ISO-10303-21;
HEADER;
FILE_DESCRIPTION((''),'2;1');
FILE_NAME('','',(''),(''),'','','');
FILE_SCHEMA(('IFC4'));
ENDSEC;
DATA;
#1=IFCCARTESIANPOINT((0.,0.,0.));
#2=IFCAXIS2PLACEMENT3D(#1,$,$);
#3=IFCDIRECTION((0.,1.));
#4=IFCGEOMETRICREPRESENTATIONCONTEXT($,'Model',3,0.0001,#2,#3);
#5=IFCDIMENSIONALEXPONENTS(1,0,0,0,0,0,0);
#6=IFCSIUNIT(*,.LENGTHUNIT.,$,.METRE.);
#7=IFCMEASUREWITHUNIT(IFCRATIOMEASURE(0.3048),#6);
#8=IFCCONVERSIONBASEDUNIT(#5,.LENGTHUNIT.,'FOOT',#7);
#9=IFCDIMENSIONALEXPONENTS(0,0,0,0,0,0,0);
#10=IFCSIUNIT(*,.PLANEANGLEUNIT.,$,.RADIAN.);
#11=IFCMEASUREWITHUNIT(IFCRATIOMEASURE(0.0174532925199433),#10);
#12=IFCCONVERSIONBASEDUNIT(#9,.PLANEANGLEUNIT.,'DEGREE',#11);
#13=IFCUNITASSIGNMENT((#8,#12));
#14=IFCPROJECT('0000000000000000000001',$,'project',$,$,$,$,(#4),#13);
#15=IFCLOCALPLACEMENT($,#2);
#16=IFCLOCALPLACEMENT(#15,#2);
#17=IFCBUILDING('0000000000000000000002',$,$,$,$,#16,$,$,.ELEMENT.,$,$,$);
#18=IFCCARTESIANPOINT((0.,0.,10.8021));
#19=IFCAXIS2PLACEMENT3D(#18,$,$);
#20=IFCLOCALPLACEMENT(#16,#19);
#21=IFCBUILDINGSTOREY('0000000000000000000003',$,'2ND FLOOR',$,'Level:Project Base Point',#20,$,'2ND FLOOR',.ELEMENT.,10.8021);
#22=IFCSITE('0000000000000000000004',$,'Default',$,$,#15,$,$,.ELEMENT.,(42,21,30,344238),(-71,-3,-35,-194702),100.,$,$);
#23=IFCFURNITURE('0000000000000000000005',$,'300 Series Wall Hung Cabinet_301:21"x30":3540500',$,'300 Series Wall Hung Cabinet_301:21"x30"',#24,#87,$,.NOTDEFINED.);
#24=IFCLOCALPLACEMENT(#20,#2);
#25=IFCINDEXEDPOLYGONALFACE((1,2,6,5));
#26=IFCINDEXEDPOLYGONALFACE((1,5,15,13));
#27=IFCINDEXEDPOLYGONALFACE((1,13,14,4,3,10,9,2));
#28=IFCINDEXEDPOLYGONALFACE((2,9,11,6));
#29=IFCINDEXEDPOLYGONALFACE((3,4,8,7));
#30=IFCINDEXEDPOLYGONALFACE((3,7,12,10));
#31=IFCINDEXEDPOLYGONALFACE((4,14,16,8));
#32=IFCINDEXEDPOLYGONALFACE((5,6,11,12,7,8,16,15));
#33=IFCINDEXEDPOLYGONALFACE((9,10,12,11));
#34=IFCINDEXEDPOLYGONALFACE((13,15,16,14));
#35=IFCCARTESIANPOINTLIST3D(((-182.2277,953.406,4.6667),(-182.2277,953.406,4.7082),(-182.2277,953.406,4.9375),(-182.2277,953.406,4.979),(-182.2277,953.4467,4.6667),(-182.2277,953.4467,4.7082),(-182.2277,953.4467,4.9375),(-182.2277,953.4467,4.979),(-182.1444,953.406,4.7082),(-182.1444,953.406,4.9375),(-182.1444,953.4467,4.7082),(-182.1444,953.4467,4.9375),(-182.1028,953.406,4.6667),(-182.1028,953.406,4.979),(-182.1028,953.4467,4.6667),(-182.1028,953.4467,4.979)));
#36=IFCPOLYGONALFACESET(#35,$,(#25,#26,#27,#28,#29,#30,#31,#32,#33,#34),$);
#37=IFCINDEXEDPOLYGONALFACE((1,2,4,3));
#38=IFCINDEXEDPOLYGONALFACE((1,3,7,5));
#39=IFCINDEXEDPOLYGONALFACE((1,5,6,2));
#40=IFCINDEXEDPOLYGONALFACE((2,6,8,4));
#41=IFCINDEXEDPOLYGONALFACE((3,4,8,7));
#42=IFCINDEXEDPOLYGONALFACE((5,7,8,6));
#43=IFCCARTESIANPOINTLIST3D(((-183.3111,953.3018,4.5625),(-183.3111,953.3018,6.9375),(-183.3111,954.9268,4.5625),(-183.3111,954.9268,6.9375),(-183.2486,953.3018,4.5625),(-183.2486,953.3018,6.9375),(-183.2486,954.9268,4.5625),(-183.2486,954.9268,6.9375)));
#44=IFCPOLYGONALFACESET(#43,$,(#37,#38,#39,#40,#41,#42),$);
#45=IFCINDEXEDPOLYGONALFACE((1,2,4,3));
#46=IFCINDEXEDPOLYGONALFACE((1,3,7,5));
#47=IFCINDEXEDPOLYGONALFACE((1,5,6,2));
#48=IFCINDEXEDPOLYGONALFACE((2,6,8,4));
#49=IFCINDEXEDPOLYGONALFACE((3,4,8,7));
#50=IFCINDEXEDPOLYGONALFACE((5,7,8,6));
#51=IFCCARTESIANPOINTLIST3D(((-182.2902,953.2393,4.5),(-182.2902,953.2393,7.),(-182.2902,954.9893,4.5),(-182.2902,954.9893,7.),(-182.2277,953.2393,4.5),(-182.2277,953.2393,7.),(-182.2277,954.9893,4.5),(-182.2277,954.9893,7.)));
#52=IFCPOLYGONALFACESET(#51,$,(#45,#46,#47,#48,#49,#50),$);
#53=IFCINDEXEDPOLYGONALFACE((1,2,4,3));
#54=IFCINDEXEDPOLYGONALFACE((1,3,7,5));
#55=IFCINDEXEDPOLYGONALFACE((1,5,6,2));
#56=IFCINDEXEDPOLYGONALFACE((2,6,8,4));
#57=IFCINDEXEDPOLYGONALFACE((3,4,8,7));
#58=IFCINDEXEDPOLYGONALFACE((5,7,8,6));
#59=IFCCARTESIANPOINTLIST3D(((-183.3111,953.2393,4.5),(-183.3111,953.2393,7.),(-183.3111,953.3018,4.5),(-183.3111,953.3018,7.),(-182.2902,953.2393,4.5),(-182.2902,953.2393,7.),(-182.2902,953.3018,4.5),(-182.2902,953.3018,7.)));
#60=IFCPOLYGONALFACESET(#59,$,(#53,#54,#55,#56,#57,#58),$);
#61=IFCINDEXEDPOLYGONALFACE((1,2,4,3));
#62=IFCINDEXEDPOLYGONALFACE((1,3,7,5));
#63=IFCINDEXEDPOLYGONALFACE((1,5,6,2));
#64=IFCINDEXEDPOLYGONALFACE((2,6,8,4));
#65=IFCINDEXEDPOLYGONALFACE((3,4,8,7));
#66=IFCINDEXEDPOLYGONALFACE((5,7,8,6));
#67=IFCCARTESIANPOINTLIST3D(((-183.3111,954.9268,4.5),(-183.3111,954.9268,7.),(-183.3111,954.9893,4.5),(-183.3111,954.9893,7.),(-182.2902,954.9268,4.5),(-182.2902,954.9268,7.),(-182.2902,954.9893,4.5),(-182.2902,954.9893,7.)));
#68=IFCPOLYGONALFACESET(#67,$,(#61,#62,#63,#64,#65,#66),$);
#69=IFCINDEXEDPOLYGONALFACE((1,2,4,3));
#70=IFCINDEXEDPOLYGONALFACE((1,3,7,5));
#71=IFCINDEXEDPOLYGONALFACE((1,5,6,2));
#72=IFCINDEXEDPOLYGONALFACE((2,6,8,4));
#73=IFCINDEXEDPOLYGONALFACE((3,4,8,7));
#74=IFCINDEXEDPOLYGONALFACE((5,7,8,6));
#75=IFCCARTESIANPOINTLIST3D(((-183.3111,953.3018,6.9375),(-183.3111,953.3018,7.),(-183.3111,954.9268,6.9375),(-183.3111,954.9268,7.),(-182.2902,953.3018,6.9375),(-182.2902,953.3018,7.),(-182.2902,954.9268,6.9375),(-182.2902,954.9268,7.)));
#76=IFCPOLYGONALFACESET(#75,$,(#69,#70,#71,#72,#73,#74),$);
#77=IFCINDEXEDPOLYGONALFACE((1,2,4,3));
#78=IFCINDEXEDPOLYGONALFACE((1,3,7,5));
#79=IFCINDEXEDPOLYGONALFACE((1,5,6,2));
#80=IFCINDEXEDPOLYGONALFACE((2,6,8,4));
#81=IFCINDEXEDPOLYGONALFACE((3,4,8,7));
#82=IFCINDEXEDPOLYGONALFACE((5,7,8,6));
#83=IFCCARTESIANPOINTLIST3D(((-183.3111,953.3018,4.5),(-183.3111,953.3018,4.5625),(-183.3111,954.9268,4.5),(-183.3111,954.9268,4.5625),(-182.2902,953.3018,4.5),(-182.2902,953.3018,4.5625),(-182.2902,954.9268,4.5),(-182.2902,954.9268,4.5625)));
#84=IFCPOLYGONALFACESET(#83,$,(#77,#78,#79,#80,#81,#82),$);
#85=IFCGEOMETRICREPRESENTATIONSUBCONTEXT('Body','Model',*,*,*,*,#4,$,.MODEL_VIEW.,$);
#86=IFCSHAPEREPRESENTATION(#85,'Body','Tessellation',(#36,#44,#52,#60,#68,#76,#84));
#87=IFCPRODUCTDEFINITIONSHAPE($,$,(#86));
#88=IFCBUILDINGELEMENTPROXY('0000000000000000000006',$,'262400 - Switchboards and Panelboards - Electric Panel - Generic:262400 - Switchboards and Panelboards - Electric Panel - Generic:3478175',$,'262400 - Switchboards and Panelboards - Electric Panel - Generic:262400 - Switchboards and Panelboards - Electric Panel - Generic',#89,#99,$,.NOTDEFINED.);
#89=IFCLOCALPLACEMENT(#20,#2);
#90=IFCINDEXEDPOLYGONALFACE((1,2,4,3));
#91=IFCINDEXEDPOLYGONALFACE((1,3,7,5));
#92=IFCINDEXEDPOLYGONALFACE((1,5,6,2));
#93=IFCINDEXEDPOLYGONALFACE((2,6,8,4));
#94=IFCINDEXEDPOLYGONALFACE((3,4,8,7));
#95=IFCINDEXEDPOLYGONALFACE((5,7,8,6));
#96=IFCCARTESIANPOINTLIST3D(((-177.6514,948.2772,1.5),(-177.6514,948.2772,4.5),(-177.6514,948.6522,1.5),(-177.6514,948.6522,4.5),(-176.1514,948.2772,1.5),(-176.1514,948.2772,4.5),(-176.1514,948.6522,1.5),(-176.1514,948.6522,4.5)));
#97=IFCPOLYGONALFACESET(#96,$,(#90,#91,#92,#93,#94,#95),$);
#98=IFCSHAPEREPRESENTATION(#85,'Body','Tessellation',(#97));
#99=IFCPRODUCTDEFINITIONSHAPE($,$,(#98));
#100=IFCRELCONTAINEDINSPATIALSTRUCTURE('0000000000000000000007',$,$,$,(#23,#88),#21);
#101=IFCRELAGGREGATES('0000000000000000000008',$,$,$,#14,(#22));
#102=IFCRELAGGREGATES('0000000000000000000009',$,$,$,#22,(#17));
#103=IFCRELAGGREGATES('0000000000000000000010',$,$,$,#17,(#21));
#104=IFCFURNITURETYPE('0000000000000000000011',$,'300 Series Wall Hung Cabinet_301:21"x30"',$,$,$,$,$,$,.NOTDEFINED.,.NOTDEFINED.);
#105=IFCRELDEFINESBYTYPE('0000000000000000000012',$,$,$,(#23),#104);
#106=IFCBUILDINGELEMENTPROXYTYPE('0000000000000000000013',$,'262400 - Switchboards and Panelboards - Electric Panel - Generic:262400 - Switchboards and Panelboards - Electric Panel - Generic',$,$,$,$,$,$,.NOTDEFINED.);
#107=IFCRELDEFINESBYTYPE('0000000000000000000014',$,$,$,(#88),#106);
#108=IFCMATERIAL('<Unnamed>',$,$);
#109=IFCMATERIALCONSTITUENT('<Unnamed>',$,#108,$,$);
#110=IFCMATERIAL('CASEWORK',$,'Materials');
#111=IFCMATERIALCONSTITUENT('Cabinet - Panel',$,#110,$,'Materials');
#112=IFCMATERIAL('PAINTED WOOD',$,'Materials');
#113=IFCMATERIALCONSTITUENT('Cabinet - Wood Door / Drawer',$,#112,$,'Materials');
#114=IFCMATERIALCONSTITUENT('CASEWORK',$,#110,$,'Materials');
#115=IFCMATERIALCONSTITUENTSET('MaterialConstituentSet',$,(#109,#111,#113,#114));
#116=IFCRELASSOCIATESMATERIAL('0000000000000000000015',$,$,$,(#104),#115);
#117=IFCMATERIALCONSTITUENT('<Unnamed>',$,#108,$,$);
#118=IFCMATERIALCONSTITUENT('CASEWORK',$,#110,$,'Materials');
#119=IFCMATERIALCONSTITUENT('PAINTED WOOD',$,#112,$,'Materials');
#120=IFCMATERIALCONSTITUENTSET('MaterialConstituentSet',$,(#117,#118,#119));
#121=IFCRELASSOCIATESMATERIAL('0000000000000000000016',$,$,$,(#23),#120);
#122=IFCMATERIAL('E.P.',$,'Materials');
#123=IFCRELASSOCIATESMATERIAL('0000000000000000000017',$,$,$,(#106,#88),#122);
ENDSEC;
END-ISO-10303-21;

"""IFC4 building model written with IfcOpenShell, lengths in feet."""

from ifc_helpers import new_model, entity, si_unit, converted_unit, direction, frame, frame_2d, origin, origin_2d_with_axis, place, context, subcontext, project, spatial, polyline, rectangle, outline, extrude, source, transform, mapped, material, constituent, constituent_set, type_object, type_shapes, element, save


model = new_model("IFC4")

# Units and contexts
model_context = context("Model", 3, precision=0.0001, world=origin(), true_north=direction((0.0, 1.0)))
body_context = subcontext(model_context, "Body", "Model", "MODEL_VIEW")
ifc_project = project(units=[converted_unit("LENGTHUNIT", "FOOT", entity("IfcRatioMeasure", 0.3048), si_unit("LENGTHUNIT", "METRE"), dimensions=[1, 0, 0, 0, 0, 0, 0]), converted_unit("PLANEANGLEUNIT", "DEGREE", entity("IfcRatioMeasure", 0.0174532925199433), si_unit("PLANEANGLEUNIT", "RADIAN"), dimensions=[0, 0, 0, 0, 0, 0, 0])], contexts=[model_context])

# Site, building, storey
site_placement = place(None, origin())
site = spatial("IfcSite", under=ifc_project, at=site_placement, Name="Default", CompositionType="ELEMENT", RefLatitude=(42, 21, 30, 344238), RefLongitude=(-71, -3, -35, -194702), RefElevation=100.0)
building_placement = place(site_placement, origin())
building = spatial("IfcBuilding", under=site, at=building_placement, CompositionType="ELEMENT")
storey_placement = place(building_placement, frame((0.0, 0.0, 10.8021)))
storey = spatial("IfcBuildingStorey", under=building, at=storey_placement, Name="2ND FLOOR", ObjectType="Level:Project Base Point", LongName="2ND FLOOR", CompositionType="ELEMENT", Elevation=10.8021)

# Shared definitions
ifc_material_1 = material(Name="PAINTED WOOD", Category="Materials")
ifc_material_2 = material(Name="CASEWORK", Category="Materials")

# Furniture
ifc_material_3 = material(Name="<Unnamed>")
ifc_constituent_1 = constituent(ifc_material_3, Name="<Unnamed>")
ifc_constituent_2 = constituent(ifc_material_2, Name="CASEWORK", Category="Materials")
ifc_constituent_3 = constituent(ifc_material_1, Name="PAINTED WOOD", Category="Materials")
ifc_constituent_set_1 = constituent_set(constituents=[ifc_constituent_1, ifc_constituent_2, ifc_constituent_3], Name="MaterialConstituentSet")
ifc_constituent_4 = constituent(ifc_material_3, Name="<Unnamed>")
ifc_constituent_5 = constituent(ifc_material_2, Name="Cabinet - Panel", Category="Materials")
ifc_constituent_6 = constituent(ifc_material_1, Name="Cabinet - Wood Door / Drawer", Category="Materials")
ifc_constituent_7 = constituent(ifc_material_2, Name="CASEWORK", Category="Materials")
ifc_constituent_set_2 = constituent_set(constituents=[ifc_constituent_4, ifc_constituent_5, ifc_constituent_6, ifc_constituent_7], Name="MaterialConstituentSet")
furniture_type_1 = type_object("IfcFurnitureType", Name="300 Series Wall Hung Cabinet_301:21\"x30\"", AssemblyPlace="NOTDEFINED", PredefinedType="NOTDEFINED", material=ifc_constituent_set_2)
shared_shape_1 = source(origin(), body_context, "Body", "SweptSolid", [
    extrude(outline(polyline([(0.1146, -0.0521), (0.1562, -0.0521), (0.1562, 0.0729), (-0.1562, 0.0729), (-0.1562, -0.0521), (-0.1146, -0.0521), (-0.1146, 0.0313), (0.1146, 0.0313), (0.1146, -0.0521)])), frame((0.1667, 0.0729, 0.3229), z_axis=(1.0, 0.0, 0.0), x_axis=(0.0, 0.0, 1.0)), (0.0, 0.0, 1.0), 0.0407),
    extrude(rectangle(XDim=1.625, YDim=0.0625, at=origin_2d_with_axis()), frame((0.875, 1.177, 0.0625), z_axis=(0.0, 0.0, 1.0), x_axis=(-1.0, 0.0, 0.0)), (0.0, 0.0, 1.0), 2.375),
    extrude(rectangle(XDim=1.75, YDim=0.0625, at=origin_2d_with_axis()), frame((0.875, 0.1562, 0.0), z_axis=(0.0, 0.0, 1.0), x_axis=(-1.0, 0.0, 0.0)), (0.0, 0.0, 1.0), 2.5),
    extrude(rectangle(XDim=1.0208, YDim=0.0625, at=frame_2d((0.0, 0.0), x_axis=(1.0, 0.0))), frame((0.0313, 0.6979, 0.0), z_axis=(0.0, 0.0, 1.0), x_axis=(0.0, -1.0, 0.0)), (0.0, 0.0, 1.0), 2.5),
    extrude(rectangle(XDim=1.0208, YDim=0.0625, at=frame_2d((0.0, 0.0), x_axis=(1.0, 0.0))), frame((1.7188, 0.6979, 0.0), z_axis=(0.0, 0.0, 1.0), x_axis=(0.0, -1.0, 0.0)), (0.0, 0.0, 1.0), 2.5),
    extrude(rectangle(XDim=1.0208, YDim=1.625, at=origin_2d_with_axis()), frame((0.875, 0.6979, 2.4375), z_axis=(0.0, 0.0, 1.0), x_axis=(0.0, 1.0, 0.0)), (0.0, 0.0, 1.0), 0.0625),
    extrude(rectangle(XDim=1.0208, YDim=1.625, at=origin_2d_with_axis()), frame((0.875, 0.6979, 0.0), z_axis=(0.0, 0.0, 1.0), x_axis=(0.0, 1.0, 0.0)), (0.0, 0.0, 1.0), 0.0625),
])
type_shapes(furniture_type_1, [shared_shape_1])
furniture_1_placement = place(storey_placement, frame((-182.1028, 953.2393, 4.5), z_axis=(0.0, 0.0, 1.0), x_axis=(0.0, 1.0, 0.0)))
element("IfcFurniture", 1, at=furniture_1_placement, inside=storey, type_object=furniture_type_1, material=ifc_constituent_set_1, Name="300 Series Wall Hung Cabinet_301:21\"x30\":3540500", ObjectType="300 Series Wall Hung Cabinet_301:21\"x30\"", PredefinedType="NOTDEFINED", context=body_context, shape_type="MappedRepresentation", body=[
    mapped(shared_shape_1, transform((0.0, 0.0, 0.0), scale=1.0)),
])

# Building element proxy
ifc_material_4 = material(Name="E.P.", Category="Materials")
building_element_proxy_type_1 = type_object("IfcBuildingElementProxyType", Name="262400 - Switchboards and Panelboards - Electric Panel - Generic:262400 - Switchboards and Panelboards - Electric Panel - Generic", PredefinedType="NOTDEFINED", material=ifc_material_4)
shared_shape_2 = source(origin(), body_context, "Body", "SweptSolid", [
    extrude(rectangle(XDim=0.375, YDim=1.5, at=origin_2d_with_axis()), frame((0.75, 0.1875, 0.0), z_axis=(0.0, 0.0, 1.0), x_axis=(0.0, 1.0, 0.0)), (0.0, 0.0, 1.0), 3.0),
])
type_shapes(building_element_proxy_type_1, [shared_shape_2])
proxy_1_placement = place(storey_placement, frame((-177.6514, 948.2772, 1.5)))
element("IfcBuildingElementProxy", 2, at=proxy_1_placement, inside=storey, type_object=building_element_proxy_type_1, material=ifc_material_4, Name="262400 - Switchboards and Panelboards - Electric Panel - Generic:262400 - Switchboards and Panelboards - Electric Panel - Generic:3478175", ObjectType="262400 - Switchboards and Panelboards - Electric Panel - Generic:262400 - Switchboards and Panelboards - Electric Panel - Generic", PredefinedType="NOTDEFINED", context=body_context, shape_type="MappedRepresentation", body=[
    mapped(shared_shape_2, transform((0.0, 0.0, 0.0), scale=1.0)),
])

save(model, "model.ifc")
